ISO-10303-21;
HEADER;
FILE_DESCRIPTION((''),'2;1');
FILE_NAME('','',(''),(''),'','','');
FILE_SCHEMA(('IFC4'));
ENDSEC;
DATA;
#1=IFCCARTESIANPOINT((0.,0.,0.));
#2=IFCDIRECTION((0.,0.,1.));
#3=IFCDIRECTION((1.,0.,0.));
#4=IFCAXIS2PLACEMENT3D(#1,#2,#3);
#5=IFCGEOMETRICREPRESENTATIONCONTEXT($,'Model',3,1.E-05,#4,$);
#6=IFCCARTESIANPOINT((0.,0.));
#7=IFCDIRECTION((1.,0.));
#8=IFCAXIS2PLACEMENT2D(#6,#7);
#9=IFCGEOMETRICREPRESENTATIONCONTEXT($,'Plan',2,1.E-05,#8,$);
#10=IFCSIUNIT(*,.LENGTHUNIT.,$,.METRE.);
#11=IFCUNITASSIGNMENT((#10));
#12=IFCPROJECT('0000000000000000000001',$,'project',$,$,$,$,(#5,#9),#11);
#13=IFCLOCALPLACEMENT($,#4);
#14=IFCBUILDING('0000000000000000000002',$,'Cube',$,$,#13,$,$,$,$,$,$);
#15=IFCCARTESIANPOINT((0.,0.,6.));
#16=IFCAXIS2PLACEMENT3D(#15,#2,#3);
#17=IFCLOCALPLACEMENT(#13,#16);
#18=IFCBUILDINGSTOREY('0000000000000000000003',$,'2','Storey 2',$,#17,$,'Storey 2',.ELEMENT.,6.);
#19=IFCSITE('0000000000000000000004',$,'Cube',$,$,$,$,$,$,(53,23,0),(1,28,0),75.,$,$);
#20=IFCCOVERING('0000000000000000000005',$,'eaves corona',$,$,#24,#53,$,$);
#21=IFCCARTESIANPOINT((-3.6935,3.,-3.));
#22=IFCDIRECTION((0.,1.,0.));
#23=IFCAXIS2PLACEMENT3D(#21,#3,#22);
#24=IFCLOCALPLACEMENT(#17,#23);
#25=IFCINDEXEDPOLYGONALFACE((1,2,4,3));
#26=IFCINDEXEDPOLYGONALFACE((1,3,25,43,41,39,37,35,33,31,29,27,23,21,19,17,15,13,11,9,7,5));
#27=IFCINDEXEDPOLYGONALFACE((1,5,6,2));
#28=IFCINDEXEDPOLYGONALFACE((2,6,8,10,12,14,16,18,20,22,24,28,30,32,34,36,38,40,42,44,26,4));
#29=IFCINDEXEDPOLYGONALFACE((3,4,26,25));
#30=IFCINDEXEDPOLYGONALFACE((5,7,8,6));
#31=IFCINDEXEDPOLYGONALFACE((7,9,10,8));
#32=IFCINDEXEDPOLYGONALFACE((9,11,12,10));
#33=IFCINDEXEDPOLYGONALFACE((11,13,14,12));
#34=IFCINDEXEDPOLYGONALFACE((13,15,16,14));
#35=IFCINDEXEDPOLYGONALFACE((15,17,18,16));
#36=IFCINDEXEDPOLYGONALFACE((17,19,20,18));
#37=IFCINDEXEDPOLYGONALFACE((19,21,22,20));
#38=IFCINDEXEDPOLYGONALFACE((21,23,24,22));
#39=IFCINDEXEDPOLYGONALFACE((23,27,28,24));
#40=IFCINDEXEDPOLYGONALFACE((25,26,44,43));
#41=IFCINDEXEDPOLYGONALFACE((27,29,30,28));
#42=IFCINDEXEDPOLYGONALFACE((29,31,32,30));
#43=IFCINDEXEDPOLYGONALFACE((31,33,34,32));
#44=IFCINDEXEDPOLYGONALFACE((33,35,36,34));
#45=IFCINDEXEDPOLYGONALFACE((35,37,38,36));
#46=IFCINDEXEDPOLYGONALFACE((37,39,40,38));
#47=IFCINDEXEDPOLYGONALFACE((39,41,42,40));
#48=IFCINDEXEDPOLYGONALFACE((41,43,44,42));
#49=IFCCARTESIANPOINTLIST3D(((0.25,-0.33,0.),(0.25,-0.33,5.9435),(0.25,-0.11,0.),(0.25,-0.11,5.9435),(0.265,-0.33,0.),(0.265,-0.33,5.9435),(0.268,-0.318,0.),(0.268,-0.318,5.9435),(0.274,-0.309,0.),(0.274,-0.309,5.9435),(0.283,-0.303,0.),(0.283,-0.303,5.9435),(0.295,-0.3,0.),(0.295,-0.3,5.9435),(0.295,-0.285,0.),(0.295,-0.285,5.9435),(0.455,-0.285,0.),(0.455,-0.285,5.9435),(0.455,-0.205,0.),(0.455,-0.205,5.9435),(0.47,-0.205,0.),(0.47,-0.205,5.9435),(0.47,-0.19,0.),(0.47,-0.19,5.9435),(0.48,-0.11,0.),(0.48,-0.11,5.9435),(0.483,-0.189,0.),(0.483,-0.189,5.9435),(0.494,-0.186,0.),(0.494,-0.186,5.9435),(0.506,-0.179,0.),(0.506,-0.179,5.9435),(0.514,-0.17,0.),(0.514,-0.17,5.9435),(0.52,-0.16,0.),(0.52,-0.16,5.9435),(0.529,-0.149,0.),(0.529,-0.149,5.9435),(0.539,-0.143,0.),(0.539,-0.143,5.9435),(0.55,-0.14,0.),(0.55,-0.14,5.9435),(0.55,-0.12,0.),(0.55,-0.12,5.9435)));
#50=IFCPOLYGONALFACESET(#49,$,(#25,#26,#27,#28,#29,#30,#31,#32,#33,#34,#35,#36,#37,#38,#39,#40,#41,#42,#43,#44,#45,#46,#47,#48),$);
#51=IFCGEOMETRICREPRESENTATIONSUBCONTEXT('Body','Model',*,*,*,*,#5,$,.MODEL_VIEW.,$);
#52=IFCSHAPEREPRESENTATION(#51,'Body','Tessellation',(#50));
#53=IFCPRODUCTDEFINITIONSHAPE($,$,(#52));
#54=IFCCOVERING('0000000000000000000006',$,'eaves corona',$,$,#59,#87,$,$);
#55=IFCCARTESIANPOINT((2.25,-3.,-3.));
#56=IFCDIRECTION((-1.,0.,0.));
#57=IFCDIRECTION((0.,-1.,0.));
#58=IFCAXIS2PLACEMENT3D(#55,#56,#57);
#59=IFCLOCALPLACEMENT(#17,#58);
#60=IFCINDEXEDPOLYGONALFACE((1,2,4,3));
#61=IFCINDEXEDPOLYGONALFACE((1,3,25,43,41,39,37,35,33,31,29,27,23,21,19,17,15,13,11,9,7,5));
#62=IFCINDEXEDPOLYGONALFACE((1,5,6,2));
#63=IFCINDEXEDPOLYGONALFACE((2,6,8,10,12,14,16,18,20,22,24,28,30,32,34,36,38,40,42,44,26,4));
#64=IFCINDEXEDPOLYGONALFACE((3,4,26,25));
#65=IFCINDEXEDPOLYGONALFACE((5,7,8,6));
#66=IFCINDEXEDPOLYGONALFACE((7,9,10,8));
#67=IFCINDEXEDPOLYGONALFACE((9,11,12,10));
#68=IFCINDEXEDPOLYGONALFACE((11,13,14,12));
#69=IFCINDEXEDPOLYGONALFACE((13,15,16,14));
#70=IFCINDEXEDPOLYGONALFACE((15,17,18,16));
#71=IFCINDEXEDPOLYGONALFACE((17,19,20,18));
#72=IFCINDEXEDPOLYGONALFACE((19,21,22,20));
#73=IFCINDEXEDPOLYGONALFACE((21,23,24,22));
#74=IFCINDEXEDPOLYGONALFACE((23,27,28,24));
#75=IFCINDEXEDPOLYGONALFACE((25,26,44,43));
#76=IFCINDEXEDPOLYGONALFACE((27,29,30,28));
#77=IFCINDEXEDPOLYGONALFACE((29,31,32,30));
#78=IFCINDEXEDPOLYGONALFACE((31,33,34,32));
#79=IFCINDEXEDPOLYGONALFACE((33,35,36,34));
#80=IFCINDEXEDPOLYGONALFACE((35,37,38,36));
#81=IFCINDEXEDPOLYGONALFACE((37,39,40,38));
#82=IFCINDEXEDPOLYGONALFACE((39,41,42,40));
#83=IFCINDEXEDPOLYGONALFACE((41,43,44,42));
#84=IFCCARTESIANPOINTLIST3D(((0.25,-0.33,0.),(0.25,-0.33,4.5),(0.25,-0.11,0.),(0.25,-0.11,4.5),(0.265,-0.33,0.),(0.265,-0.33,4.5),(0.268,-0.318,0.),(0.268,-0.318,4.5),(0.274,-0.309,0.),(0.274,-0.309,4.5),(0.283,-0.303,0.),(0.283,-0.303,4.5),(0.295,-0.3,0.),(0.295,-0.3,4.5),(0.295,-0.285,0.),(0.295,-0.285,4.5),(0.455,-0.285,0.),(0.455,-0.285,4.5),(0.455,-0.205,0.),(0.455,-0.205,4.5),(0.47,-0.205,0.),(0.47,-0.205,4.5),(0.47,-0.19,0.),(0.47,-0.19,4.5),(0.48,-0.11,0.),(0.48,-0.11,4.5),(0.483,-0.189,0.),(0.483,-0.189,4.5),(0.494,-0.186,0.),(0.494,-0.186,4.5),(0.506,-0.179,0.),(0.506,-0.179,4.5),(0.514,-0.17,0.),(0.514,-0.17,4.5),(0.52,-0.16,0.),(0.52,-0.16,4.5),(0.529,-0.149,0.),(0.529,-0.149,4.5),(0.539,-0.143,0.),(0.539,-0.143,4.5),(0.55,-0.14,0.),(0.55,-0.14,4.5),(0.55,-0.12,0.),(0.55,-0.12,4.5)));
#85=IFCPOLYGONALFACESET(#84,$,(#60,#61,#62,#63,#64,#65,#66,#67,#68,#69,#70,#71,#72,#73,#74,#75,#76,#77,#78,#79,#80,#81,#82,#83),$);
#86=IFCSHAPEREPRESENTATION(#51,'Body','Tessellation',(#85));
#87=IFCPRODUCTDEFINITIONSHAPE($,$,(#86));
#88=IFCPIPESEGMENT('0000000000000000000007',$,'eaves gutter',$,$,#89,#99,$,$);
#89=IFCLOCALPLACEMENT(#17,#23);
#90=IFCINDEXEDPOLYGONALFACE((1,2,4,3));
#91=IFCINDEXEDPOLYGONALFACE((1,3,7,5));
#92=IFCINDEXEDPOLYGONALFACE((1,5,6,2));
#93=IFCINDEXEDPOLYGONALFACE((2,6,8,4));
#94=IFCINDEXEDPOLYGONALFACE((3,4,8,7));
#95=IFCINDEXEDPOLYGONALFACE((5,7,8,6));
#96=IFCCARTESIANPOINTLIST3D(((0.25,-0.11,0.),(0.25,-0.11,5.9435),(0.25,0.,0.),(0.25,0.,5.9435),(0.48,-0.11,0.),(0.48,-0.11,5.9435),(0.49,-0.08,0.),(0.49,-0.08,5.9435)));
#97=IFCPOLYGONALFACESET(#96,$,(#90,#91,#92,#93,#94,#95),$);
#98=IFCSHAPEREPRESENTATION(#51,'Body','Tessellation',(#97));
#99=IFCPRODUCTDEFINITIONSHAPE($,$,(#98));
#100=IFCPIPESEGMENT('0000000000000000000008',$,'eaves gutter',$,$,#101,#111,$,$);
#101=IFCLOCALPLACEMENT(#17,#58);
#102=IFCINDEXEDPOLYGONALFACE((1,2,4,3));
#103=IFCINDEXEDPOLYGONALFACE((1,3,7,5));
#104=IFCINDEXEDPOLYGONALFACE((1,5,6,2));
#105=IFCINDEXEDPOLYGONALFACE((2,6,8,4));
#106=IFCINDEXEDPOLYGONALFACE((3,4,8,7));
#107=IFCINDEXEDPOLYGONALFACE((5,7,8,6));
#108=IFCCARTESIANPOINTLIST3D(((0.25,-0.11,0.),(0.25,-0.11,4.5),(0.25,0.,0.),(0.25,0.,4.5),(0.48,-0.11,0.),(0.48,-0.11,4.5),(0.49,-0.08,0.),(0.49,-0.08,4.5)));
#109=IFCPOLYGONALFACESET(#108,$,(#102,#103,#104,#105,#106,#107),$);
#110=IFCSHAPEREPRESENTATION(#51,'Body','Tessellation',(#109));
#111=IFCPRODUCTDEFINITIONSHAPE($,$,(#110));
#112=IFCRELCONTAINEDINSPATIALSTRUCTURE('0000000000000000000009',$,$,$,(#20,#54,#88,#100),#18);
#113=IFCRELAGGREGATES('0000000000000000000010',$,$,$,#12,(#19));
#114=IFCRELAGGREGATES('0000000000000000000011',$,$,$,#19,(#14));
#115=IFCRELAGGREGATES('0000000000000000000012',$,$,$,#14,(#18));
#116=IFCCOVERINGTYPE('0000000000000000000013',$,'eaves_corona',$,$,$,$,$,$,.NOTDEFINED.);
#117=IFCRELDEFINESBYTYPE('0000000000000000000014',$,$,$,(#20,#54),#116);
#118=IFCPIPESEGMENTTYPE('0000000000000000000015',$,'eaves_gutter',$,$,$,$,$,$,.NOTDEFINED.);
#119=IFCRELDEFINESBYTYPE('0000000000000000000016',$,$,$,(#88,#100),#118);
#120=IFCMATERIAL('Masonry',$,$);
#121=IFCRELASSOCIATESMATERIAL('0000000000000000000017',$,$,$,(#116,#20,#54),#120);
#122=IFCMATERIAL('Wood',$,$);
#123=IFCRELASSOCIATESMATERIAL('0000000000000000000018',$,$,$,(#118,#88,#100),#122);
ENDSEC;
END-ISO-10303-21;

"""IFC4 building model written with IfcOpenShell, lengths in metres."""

from ifc_helpers import new_model, si_unit, frame, origin_with_axes, origin_2d_with_axis, place, context, subcontext, project, spatial, polyline, outline, extrude, material, material_profile, profile_set, profile_usage, type_object, element, save


model = new_model("IFC4")

# Units and contexts
model_context = context("Model", 3, precision=1e-05, world=origin_with_axes())
plan_context = context("Plan", 2, precision=1e-05, world=origin_2d_with_axis())
body_context = subcontext(model_context, "Body", "Model", "MODEL_VIEW")
ifc_project = project(units=[si_unit("LENGTHUNIT", "METRE")], contexts=[model_context, plan_context])

# Site, building, storey
site = spatial("IfcSite", under=ifc_project, Name="Cube", RefLatitude=(53, 23, 0), RefLongitude=(1, 28, 0), RefElevation=75.0)
building_placement = place(None, origin_with_axes())
building = spatial("IfcBuilding", under=site, at=building_placement, Name="Cube")
storey_placement = place(building_placement, frame((0.0, 0.0, 6.0), z_axis=(0.0, 0.0, 1.0), x_axis=(1.0, 0.0, 0.0)))
storey = spatial("IfcBuildingStorey", under=building, at=storey_placement, Name="2", Description="Storey 2", LongName="Storey 2", CompositionType="ELEMENT", Elevation=6.0)

# Coverings
ifc_material_1 = material(Name="Masonry")
ifc_material_profile_1 = material_profile(ifc_material_1, outline(polyline([(0.25, -0.11), (0.25, -0.33), (0.265, -0.33), (0.268, -0.318), (0.274, -0.309), (0.283, -0.303), (0.295, -0.3), (0.295, -0.285), (0.455, -0.285), (0.455, -0.205), (0.47, -0.205), (0.47, -0.19), (0.483, -0.189), (0.494, -0.186), (0.506, -0.179), (0.514, -0.17), (0.52, -0.16), (0.529, -0.149), (0.539, -0.143), (0.55, -0.14), (0.55, -0.12), (0.48, -0.11), (0.25, -0.11)])))
ifc_profile_set_1 = profile_set([ifc_material_profile_1])
ifc_profile_usage_1 = profile_usage(ifc_profile_set_1)
covering_type_1 = type_object("IfcCoveringType", Name="eaves_corona", PredefinedType="NOTDEFINED", material=ifc_profile_set_1)
covering_1_placement = place(storey_placement, frame((-3.6935, 3.0, -3.0), z_axis=(1.0, 0.0, 0.0), x_axis=(0.0, 1.0, 0.0)))
element("IfcCovering", 1, at=covering_1_placement, inside=storey, type_object=covering_type_1, material=ifc_profile_usage_1, Name="eaves corona", context=body_context, shape_type="SweptSolid", body=[
    extrude(outline(polyline([(0.25, -0.11), (0.25, -0.33), (0.265, -0.33), (0.268, -0.318), (0.274, -0.309), (0.283, -0.303), (0.295, -0.3), (0.295, -0.285), (0.455, -0.285), (0.455, -0.205), (0.47, -0.205), (0.47, -0.19), (0.483, -0.189), (0.494, -0.186), (0.506, -0.179), (0.514, -0.17), (0.52, -0.16), (0.529, -0.149), (0.539, -0.143), (0.55, -0.14), (0.55, -0.12), (0.48, -0.11), (0.25, -0.11)])), origin_with_axes(), (0.0, 0.0, 1.0), 5.9435),
])
ifc_profile_usage_2 = profile_usage(ifc_profile_set_1)
covering_2_placement = place(storey_placement, frame((2.25, -3.0, -3.0), z_axis=(-1.0, 0.0, 0.0), x_axis=(0.0, -1.0, 0.0)))
element("IfcCovering", 2, at=covering_2_placement, inside=storey, type_object=covering_type_1, material=ifc_profile_usage_2, Name="eaves corona", context=body_context, shape_type="SweptSolid", body=[
    extrude(outline(polyline([(0.25, -0.11), (0.25, -0.33), (0.265, -0.33), (0.268, -0.318), (0.274, -0.309), (0.283, -0.303), (0.295, -0.3), (0.295, -0.285), (0.455, -0.285), (0.455, -0.205), (0.47, -0.205), (0.47, -0.19), (0.483, -0.189), (0.494, -0.186), (0.506, -0.179), (0.514, -0.17), (0.52, -0.16), (0.529, -0.149), (0.539, -0.143), (0.55, -0.14), (0.55, -0.12), (0.48, -0.11), (0.25, -0.11)])), origin_with_axes(), (0.0, 0.0, 1.0), 4.5),
])

# Pipe segments
ifc_material_2 = material(Name="Wood")
ifc_material_profile_2 = material_profile(ifc_material_2, outline(polyline([(0.25, -0.11), (0.48, -0.11), (0.49, -0.08), (0.25, 0.0), (0.25, -0.11)])))
ifc_profile_set_2 = profile_set([ifc_material_profile_2])
ifc_profile_usage_3 = profile_usage(ifc_profile_set_2)
pipe_segment_type = type_object("IfcPipeSegmentType", Name="eaves_gutter", PredefinedType="NOTDEFINED", material=ifc_profile_set_2)
pipe_segment_1_placement = place(storey_placement, frame((-3.6935, 3.0, -3.0), z_axis=(1.0, 0.0, 0.0), x_axis=(0.0, 1.0, 0.0)))
element("IfcPipeSegment", 3, at=pipe_segment_1_placement, inside=storey, type_object=pipe_segment_type, material=ifc_profile_usage_3, Name="eaves gutter", context=body_context, shape_type="SweptSolid", body=[
    extrude(outline(polyline([(0.25, -0.11), (0.48, -0.11), (0.49, -0.08), (0.25, 0.0), (0.25, -0.11)])), origin_with_axes(), (0.0, 0.0, 1.0), 5.9435),
])
ifc_profile_usage_4 = profile_usage(ifc_profile_set_2)
pipe_segment_2_placement = place(storey_placement, frame((2.25, -3.0, -3.0), z_axis=(-1.0, 0.0, 0.0), x_axis=(0.0, -1.0, 0.0)))
element("IfcPipeSegment", 4, at=pipe_segment_2_placement, inside=storey, type_object=pipe_segment_type, material=ifc_profile_usage_4, Name="eaves gutter", context=body_context, shape_type="SweptSolid", body=[
    extrude(outline(polyline([(0.25, -0.11), (0.48, -0.11), (0.49, -0.08), (0.25, 0.0), (0.25, -0.11)])), origin_with_axes(), (0.0, 0.0, 1.0), 4.5),
])

save(model, "model.ifc")
